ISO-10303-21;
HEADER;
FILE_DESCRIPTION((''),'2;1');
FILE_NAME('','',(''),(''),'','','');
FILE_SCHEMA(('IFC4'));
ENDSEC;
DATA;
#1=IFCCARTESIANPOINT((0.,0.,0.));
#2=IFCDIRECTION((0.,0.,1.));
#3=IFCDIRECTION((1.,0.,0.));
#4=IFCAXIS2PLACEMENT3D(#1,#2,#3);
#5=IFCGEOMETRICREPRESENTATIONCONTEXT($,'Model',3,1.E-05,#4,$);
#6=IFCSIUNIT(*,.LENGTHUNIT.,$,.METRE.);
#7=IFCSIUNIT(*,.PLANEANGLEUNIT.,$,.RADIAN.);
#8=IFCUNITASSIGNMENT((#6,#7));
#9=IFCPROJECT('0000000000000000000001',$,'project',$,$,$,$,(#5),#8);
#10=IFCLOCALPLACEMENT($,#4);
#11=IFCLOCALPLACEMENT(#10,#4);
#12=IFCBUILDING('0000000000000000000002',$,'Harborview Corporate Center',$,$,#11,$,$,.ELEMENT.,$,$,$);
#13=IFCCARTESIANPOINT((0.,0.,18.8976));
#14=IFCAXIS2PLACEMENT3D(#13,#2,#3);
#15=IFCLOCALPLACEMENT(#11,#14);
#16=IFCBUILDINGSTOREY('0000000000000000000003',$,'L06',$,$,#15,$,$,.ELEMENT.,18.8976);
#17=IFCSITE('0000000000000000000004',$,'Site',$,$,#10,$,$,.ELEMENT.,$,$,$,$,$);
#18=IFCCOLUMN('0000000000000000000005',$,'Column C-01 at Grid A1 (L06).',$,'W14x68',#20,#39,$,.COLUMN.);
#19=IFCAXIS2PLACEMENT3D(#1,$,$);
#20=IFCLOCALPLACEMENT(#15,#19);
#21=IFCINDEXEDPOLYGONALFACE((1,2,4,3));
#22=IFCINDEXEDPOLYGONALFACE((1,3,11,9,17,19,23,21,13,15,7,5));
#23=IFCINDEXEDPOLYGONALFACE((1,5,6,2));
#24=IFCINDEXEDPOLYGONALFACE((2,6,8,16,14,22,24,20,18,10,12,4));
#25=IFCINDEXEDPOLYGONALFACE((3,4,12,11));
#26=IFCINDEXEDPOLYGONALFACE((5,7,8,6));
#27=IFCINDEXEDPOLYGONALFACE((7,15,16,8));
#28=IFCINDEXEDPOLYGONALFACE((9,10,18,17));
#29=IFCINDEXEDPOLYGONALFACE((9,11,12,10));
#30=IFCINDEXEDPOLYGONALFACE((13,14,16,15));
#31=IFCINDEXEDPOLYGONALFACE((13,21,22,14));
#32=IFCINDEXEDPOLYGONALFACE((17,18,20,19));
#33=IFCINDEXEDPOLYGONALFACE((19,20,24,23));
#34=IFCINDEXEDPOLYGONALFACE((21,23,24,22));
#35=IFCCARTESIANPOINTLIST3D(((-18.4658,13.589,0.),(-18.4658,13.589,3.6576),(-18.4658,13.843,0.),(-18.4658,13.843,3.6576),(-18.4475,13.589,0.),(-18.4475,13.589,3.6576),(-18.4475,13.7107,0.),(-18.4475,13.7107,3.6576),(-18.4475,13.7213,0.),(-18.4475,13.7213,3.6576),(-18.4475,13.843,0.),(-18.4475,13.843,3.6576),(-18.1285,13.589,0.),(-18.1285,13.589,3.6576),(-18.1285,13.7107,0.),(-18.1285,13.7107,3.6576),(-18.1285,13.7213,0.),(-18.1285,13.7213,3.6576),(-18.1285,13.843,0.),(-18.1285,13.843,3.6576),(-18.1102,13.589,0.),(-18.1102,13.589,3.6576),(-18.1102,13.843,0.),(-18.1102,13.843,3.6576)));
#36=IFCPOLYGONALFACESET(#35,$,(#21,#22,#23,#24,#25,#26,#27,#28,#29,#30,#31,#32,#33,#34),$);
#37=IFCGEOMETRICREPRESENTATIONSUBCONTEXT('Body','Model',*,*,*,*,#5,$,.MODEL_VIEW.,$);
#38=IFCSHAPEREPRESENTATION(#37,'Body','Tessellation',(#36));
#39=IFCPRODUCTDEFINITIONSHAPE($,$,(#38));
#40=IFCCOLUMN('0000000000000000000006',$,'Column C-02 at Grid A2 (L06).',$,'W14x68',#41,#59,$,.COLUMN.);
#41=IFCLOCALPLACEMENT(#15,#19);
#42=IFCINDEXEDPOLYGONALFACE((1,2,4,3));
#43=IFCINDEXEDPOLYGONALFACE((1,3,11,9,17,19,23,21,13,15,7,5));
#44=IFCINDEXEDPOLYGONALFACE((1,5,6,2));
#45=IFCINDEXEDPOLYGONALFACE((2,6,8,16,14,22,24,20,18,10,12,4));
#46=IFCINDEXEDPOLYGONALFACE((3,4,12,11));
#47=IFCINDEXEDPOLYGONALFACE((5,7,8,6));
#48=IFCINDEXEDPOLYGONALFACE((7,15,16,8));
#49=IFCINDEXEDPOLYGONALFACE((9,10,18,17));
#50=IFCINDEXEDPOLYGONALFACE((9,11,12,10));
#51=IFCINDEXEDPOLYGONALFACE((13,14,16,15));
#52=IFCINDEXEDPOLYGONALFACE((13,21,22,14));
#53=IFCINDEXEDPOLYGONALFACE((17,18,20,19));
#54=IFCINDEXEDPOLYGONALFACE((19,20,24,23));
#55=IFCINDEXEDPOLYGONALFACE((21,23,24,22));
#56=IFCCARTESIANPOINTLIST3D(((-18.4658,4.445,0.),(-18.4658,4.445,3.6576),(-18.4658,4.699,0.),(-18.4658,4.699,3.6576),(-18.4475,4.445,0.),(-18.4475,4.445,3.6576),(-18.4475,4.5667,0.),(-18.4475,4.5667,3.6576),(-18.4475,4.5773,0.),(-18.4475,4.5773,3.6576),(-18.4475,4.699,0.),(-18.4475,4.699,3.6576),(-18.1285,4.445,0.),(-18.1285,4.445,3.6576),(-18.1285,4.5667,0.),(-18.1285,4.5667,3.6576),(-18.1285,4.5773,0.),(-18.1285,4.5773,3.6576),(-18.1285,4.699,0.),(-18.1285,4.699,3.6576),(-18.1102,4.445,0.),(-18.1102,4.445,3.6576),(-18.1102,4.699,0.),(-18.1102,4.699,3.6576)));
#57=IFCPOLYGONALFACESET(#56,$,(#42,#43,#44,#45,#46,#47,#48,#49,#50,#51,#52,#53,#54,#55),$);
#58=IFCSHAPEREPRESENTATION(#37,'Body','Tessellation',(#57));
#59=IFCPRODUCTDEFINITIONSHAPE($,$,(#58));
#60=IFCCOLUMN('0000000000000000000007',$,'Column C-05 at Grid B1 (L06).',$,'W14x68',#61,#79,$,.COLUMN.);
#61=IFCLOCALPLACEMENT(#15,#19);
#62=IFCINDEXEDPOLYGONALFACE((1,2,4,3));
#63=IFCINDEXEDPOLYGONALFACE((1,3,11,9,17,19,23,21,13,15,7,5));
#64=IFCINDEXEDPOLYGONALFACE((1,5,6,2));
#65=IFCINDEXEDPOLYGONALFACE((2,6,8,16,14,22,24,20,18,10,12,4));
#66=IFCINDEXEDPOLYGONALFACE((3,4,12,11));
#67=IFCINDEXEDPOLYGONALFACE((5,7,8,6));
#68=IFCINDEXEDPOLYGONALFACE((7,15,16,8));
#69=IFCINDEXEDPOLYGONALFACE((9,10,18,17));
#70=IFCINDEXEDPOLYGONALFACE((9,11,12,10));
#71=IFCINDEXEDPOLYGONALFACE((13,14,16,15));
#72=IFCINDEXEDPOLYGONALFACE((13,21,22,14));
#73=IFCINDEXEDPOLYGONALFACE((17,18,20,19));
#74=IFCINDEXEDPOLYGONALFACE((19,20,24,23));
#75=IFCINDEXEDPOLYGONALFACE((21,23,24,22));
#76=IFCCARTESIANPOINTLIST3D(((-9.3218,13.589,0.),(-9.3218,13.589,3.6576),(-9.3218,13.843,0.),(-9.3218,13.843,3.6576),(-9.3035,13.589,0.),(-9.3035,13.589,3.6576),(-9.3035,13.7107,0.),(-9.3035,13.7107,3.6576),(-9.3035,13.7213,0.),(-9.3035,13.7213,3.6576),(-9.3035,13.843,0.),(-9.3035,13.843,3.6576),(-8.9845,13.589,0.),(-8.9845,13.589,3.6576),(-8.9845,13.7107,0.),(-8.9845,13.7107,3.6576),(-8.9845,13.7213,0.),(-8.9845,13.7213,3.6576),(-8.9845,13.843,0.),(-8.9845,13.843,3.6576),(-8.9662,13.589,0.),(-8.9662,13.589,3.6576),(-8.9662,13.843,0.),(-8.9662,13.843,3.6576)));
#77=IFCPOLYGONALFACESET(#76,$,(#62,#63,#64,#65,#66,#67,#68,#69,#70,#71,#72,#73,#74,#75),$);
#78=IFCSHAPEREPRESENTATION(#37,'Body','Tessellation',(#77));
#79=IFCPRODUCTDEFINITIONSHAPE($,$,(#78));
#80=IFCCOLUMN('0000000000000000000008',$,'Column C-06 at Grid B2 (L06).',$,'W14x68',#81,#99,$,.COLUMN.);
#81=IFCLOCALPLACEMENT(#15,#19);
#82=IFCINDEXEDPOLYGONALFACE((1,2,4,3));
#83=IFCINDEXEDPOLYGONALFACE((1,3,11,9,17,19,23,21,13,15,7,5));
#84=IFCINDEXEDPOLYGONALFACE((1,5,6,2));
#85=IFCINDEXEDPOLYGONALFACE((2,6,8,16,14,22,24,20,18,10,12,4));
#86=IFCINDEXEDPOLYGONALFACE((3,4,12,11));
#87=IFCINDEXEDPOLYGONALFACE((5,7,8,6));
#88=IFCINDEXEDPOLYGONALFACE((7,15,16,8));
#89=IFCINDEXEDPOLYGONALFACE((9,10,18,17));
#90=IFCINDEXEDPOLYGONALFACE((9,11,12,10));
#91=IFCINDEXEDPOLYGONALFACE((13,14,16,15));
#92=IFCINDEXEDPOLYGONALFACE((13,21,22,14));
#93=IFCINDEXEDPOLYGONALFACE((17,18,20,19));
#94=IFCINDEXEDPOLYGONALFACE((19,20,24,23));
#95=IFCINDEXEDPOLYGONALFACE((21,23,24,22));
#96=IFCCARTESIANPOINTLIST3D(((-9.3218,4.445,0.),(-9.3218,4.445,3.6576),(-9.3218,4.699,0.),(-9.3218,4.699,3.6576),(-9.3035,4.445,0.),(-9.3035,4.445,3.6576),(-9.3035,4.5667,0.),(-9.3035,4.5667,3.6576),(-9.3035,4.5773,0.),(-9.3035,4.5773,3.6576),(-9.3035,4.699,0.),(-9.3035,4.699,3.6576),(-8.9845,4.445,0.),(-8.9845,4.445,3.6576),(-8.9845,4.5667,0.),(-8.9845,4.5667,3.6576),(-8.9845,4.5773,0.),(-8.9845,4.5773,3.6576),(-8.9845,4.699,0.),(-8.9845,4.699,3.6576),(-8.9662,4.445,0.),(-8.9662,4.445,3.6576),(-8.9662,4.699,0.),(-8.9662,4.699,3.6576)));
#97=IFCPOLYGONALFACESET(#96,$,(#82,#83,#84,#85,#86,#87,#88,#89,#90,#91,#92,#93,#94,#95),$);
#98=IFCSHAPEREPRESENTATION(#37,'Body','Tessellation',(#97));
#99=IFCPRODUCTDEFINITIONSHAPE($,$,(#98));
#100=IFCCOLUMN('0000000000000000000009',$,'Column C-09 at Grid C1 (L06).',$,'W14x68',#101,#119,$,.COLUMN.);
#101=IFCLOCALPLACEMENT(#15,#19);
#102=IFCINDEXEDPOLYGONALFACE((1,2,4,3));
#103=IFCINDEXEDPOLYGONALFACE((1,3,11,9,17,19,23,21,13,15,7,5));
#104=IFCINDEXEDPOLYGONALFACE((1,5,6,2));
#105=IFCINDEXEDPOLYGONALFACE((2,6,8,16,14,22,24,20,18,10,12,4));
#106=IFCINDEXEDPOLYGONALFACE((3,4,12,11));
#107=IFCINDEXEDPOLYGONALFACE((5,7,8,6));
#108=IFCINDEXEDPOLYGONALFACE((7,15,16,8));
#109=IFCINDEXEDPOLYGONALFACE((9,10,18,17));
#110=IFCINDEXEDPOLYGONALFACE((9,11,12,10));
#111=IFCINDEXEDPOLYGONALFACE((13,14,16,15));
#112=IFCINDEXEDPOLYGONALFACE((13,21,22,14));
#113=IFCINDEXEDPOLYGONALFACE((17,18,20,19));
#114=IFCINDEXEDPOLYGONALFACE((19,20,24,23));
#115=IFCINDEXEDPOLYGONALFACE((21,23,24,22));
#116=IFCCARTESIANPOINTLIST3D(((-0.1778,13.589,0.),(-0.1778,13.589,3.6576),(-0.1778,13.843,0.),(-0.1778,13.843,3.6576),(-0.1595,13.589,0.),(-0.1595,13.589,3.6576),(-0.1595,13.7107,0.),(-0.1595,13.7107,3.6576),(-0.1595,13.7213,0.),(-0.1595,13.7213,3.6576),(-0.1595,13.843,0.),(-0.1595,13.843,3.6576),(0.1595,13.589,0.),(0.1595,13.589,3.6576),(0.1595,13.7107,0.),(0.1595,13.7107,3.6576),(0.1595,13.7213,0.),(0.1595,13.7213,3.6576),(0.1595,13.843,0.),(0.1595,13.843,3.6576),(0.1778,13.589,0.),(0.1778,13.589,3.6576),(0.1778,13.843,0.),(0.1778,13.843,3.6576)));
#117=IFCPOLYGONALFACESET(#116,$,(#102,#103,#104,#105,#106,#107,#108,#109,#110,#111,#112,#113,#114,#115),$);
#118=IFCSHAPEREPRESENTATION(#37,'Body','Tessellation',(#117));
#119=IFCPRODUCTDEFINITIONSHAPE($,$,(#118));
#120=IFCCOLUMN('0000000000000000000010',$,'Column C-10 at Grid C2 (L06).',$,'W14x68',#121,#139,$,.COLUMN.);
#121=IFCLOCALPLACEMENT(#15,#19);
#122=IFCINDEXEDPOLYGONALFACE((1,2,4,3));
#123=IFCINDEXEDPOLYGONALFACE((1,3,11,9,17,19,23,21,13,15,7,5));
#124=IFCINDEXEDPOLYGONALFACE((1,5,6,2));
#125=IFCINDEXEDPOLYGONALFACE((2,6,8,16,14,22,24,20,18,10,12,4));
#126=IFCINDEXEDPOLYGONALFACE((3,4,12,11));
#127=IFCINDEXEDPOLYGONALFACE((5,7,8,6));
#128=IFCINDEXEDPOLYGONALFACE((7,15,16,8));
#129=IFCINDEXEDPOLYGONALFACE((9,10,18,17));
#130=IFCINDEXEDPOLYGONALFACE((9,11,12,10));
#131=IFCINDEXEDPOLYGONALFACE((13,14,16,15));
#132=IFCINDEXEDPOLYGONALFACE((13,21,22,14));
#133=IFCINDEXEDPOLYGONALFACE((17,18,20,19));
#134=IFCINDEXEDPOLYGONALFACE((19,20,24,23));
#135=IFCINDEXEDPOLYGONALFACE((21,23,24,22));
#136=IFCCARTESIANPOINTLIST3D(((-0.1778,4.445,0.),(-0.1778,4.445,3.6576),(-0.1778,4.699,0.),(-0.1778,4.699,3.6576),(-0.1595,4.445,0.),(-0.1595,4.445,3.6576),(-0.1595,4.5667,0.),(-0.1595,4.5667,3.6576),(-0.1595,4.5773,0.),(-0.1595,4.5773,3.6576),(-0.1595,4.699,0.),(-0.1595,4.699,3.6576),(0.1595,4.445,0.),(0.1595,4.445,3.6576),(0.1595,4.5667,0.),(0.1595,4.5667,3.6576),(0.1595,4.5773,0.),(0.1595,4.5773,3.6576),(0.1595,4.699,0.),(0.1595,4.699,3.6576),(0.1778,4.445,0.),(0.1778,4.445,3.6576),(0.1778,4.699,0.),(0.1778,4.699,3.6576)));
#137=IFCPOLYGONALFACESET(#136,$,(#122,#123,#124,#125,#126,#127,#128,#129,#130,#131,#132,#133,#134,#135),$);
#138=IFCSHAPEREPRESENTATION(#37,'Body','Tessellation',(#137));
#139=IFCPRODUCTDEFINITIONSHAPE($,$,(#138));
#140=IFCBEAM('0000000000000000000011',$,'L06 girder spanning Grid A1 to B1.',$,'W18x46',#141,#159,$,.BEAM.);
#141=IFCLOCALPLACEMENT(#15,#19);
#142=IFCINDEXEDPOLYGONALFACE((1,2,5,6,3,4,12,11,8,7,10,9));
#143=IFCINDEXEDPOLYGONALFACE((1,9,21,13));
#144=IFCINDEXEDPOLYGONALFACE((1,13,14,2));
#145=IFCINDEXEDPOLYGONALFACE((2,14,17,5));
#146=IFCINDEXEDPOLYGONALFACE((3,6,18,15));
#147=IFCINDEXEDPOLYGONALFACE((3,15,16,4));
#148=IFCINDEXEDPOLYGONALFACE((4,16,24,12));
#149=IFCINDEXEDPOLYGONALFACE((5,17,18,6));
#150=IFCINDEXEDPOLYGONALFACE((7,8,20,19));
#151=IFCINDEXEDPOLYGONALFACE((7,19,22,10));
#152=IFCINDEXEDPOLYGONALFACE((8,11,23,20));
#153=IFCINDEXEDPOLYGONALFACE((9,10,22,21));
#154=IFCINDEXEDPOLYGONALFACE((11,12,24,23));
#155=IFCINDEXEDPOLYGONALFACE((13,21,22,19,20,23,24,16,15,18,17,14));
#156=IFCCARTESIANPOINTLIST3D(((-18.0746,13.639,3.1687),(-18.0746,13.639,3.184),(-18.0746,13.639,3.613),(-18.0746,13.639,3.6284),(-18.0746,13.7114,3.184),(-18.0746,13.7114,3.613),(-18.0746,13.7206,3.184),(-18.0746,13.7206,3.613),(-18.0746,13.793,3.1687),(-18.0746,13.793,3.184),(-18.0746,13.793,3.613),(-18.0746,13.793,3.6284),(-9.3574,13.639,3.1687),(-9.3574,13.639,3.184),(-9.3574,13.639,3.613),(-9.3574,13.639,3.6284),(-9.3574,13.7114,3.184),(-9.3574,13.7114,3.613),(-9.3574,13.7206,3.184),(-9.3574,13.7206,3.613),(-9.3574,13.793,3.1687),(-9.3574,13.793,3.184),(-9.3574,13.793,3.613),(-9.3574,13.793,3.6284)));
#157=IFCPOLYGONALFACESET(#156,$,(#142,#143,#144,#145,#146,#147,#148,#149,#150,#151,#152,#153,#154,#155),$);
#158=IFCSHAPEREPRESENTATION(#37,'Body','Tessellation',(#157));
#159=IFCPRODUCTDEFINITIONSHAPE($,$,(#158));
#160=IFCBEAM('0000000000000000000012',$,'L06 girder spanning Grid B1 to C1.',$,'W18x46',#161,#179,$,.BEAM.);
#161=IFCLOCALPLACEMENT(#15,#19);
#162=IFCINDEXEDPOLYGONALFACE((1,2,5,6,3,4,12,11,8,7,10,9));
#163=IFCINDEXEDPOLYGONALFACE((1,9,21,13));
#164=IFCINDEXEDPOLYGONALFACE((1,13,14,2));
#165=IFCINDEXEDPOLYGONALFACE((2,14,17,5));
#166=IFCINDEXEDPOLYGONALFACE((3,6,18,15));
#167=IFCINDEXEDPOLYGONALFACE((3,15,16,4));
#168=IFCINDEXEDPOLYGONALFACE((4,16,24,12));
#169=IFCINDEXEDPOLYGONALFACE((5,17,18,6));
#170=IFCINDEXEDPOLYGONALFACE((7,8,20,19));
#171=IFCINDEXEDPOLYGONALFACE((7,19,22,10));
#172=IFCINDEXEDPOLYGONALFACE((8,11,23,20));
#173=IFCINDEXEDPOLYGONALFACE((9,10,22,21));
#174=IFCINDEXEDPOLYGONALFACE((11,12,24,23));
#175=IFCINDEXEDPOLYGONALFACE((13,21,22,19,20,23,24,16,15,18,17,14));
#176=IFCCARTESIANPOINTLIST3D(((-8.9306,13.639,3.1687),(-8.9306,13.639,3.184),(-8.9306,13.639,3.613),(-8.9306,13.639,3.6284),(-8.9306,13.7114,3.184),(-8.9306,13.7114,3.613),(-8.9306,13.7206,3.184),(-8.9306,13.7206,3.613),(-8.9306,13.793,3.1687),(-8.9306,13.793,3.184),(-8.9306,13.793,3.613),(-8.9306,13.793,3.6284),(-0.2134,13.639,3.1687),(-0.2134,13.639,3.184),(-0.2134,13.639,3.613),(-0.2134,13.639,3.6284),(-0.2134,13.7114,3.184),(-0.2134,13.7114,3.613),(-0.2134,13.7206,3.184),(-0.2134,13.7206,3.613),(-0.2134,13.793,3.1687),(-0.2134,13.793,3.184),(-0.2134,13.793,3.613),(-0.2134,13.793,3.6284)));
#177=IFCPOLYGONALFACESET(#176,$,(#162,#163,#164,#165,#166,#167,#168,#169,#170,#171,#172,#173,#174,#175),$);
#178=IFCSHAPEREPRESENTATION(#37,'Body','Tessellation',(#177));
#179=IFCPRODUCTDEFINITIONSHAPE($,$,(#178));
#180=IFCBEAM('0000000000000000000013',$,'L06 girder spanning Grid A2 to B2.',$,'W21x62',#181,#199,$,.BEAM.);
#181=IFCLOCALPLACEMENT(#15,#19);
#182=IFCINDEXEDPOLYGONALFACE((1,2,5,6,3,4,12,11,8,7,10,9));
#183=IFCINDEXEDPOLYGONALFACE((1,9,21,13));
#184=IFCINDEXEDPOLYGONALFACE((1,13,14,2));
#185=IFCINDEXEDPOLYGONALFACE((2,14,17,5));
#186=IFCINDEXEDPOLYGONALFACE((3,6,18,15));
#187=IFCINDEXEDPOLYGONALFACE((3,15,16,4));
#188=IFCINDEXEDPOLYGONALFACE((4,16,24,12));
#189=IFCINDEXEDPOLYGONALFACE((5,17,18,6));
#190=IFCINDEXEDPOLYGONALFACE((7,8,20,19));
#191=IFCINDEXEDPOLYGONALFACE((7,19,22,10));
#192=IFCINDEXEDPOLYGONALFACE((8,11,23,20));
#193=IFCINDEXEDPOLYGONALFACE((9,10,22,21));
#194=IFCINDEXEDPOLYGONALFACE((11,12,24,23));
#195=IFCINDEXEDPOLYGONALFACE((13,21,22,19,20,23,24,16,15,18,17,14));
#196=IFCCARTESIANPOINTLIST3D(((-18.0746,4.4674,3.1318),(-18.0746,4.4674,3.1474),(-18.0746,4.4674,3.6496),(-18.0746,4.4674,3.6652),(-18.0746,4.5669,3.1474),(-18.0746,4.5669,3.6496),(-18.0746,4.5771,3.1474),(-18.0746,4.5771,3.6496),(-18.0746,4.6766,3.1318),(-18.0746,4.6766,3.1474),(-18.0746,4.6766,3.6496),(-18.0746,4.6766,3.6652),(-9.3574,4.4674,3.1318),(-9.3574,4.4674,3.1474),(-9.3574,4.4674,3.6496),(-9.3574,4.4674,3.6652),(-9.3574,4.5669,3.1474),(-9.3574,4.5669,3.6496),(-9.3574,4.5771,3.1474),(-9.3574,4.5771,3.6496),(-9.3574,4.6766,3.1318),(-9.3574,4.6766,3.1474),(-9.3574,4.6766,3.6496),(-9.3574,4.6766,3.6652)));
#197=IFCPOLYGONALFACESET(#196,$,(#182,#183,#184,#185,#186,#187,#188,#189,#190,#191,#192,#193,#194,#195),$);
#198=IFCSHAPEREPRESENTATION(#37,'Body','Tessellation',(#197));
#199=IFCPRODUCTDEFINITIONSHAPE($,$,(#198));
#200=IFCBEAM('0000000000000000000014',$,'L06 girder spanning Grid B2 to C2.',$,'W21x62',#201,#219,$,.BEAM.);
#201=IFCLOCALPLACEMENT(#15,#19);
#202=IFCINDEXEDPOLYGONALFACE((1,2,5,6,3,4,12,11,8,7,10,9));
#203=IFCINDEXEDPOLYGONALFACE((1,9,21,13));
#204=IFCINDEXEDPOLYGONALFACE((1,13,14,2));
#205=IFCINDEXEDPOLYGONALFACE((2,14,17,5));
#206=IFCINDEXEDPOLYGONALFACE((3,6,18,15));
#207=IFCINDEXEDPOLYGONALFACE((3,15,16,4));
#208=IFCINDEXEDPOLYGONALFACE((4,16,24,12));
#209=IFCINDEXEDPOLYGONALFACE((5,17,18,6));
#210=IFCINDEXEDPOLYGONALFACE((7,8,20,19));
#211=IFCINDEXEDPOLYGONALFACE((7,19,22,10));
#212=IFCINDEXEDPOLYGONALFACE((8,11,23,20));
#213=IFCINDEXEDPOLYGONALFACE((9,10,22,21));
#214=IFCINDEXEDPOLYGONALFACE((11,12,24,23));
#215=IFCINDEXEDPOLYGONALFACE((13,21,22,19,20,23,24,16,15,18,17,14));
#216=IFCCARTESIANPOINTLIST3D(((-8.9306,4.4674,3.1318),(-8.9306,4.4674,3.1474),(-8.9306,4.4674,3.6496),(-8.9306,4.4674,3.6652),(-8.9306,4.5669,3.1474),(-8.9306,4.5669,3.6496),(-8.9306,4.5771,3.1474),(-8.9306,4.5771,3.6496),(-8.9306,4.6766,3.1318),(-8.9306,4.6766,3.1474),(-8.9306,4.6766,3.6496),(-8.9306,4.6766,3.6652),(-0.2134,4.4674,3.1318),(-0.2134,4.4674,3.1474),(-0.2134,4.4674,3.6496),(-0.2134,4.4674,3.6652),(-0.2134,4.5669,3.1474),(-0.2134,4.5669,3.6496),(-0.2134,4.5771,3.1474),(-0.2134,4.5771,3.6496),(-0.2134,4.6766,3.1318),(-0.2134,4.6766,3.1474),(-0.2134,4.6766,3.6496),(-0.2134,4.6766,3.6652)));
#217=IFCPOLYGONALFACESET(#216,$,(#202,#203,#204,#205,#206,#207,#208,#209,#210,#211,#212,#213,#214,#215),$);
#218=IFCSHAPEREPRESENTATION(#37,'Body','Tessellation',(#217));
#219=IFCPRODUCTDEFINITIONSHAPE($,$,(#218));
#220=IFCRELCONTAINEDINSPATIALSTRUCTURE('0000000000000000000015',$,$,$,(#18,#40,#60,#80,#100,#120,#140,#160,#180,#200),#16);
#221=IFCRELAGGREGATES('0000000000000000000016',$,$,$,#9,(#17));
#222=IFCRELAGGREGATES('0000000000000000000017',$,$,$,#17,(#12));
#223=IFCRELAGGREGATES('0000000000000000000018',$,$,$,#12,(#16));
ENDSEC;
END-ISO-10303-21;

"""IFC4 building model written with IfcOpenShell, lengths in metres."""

from ifc_helpers import new_model, si_unit, frame, origin_with_axes, place, context, subcontext, project, spatial, i_section, extrude, element, save


model = new_model("IFC4")

# Units and contexts
model_context = context("Model", 3, precision=1e-05, world=origin_with_axes())
body_context = subcontext(model_context, "Body", "Model", "MODEL_VIEW")
ifc_project = project(units=[si_unit("LENGTHUNIT", "METRE"), si_unit("PLANEANGLEUNIT", "RADIAN")], contexts=[model_context])

# Site, building, storey
site_placement = place(None, origin_with_axes())
site = spatial("IfcSite", under=ifc_project, at=site_placement, Name="Site", CompositionType="ELEMENT")
building_placement = place(site_placement, origin_with_axes())
building = spatial("IfcBuilding", under=site, at=building_placement, Name="Harborview Corporate Center", CompositionType="ELEMENT")
storey_placement = place(building_placement, frame((0.0, 0.0, 18.8976), z_axis=(0.0, 0.0, 1.0), x_axis=(1.0, 0.0, 0.0)))
storey = spatial("IfcBuildingStorey", under=building, at=storey_placement, Name="L06", CompositionType="ELEMENT", Elevation=18.8976)

# Columns
for number, where, z_axis, x_axis, name in (
    (1, (-18.288, 13.716, 0.0), (0.0, 0.0, 1.0), (0.0, 1.0, 0.0), "Column C-01 at Grid A1 (L06)."),
    (2, (-18.288, 4.572, 0.0), (0.0, 0.0, 1.0), (0.0, 1.0, 0.0), "Column C-02 at Grid A2 (L06)."),
    (3, (-9.144, 13.716, 0.0), (0.0, 0.0, 1.0), (0.0, 1.0, 0.0), "Column C-05 at Grid B1 (L06)."),
    (4, (-9.144, 4.572, 0.0), (0.0, 0.0, 1.0), (0.0, 1.0, 0.0), "Column C-06 at Grid B2 (L06)."),
    (5, (0.0, 13.716, 0.0), (0.0, 0.0, 1.0), (0.0, 1.0, 0.0), "Column C-09 at Grid C1 (L06)."),
    (6, (0.0, 4.572, 0.0), (0.0, 0.0, 1.0), (0.0, 1.0, 0.0), "Column C-10 at Grid C2 (L06)."),
):
    element("IfcColumn", number, at=place(storey_placement, frame(where, z_axis=z_axis, x_axis=x_axis)), inside=storey, Name=name, ObjectType="W14x68", PredefinedType="COLUMN", context=body_context, shape_type="SweptSolid", body=[
        extrude(i_section(OverallWidth=0.254, OverallDepth=0.3556, WebThickness=0.0105, FlangeThickness=0.0183), origin_with_axes(), (0.0, 0.0, 1.0), 3.6576),
    ])

# Beams
beam_1_placement = place(storey_placement, frame((-18.0746, 13.716, 3.3985), z_axis=(1.0, 0.0, 0.0), x_axis=(0.0, 1.0, 0.0)))
element("IfcBeam", 7, at=beam_1_placement, inside=storey, Name="L06 girder spanning Grid A1 to B1.", ObjectType="W18x46", PredefinedType="BEAM", context=body_context, shape_type="SweptSolid", body=[
    extrude(i_section(OverallWidth=0.1539, OverallDepth=0.4597, WebThickness=0.0091, FlangeThickness=0.0154), origin_with_axes(), (0.0, 0.0, 1.0), 8.7173),
])
beam_2_placement = place(storey_placement, frame((-8.9306, 13.716, 3.3985), z_axis=(1.0, 0.0, 0.0), x_axis=(0.0, 1.0, 0.0)))
element("IfcBeam", 8, at=beam_2_placement, inside=storey, Name="L06 girder spanning Grid B1 to C1.", ObjectType="W18x46", PredefinedType="BEAM", context=body_context, shape_type="SweptSolid", body=[
    extrude(i_section(OverallWidth=0.1539, OverallDepth=0.4597, WebThickness=0.0091, FlangeThickness=0.0154), origin_with_axes(), (0.0, 0.0, 1.0), 8.7173),
])
beam_3_placement = place(storey_placement, frame((-18.0746, 4.572, 3.3985), z_axis=(1.0, 0.0, 0.0), x_axis=(0.0, 1.0, 0.0)))
element("IfcBeam", 9, at=beam_3_placement, inside=storey, Name="L06 girder spanning Grid A2 to B2.", ObjectType="W21x62", PredefinedType="BEAM", context=body_context, shape_type="SweptSolid", body=[
    extrude(i_section(OverallWidth=0.2093, OverallDepth=0.5334, WebThickness=0.0102, FlangeThickness=0.0156), origin_with_axes(), (0.0, 0.0, 1.0), 8.7173),
])
beam_4_placement = place(storey_placement, frame((-8.9306, 4.572, 3.3985), z_axis=(1.0, 0.0, 0.0), x_axis=(0.0, 1.0, 0.0)))
element("IfcBeam", 10, at=beam_4_placement, inside=storey, Name="L06 girder spanning Grid B2 to C2.", ObjectType="W21x62", PredefinedType="BEAM", context=body_context, shape_type="SweptSolid", body=[
    extrude(i_section(OverallWidth=0.2093, OverallDepth=0.5334, WebThickness=0.0102, FlangeThickness=0.0156), origin_with_axes(), (0.0, 0.0, 1.0), 8.7173),
])

save(model, "model.ifc")
